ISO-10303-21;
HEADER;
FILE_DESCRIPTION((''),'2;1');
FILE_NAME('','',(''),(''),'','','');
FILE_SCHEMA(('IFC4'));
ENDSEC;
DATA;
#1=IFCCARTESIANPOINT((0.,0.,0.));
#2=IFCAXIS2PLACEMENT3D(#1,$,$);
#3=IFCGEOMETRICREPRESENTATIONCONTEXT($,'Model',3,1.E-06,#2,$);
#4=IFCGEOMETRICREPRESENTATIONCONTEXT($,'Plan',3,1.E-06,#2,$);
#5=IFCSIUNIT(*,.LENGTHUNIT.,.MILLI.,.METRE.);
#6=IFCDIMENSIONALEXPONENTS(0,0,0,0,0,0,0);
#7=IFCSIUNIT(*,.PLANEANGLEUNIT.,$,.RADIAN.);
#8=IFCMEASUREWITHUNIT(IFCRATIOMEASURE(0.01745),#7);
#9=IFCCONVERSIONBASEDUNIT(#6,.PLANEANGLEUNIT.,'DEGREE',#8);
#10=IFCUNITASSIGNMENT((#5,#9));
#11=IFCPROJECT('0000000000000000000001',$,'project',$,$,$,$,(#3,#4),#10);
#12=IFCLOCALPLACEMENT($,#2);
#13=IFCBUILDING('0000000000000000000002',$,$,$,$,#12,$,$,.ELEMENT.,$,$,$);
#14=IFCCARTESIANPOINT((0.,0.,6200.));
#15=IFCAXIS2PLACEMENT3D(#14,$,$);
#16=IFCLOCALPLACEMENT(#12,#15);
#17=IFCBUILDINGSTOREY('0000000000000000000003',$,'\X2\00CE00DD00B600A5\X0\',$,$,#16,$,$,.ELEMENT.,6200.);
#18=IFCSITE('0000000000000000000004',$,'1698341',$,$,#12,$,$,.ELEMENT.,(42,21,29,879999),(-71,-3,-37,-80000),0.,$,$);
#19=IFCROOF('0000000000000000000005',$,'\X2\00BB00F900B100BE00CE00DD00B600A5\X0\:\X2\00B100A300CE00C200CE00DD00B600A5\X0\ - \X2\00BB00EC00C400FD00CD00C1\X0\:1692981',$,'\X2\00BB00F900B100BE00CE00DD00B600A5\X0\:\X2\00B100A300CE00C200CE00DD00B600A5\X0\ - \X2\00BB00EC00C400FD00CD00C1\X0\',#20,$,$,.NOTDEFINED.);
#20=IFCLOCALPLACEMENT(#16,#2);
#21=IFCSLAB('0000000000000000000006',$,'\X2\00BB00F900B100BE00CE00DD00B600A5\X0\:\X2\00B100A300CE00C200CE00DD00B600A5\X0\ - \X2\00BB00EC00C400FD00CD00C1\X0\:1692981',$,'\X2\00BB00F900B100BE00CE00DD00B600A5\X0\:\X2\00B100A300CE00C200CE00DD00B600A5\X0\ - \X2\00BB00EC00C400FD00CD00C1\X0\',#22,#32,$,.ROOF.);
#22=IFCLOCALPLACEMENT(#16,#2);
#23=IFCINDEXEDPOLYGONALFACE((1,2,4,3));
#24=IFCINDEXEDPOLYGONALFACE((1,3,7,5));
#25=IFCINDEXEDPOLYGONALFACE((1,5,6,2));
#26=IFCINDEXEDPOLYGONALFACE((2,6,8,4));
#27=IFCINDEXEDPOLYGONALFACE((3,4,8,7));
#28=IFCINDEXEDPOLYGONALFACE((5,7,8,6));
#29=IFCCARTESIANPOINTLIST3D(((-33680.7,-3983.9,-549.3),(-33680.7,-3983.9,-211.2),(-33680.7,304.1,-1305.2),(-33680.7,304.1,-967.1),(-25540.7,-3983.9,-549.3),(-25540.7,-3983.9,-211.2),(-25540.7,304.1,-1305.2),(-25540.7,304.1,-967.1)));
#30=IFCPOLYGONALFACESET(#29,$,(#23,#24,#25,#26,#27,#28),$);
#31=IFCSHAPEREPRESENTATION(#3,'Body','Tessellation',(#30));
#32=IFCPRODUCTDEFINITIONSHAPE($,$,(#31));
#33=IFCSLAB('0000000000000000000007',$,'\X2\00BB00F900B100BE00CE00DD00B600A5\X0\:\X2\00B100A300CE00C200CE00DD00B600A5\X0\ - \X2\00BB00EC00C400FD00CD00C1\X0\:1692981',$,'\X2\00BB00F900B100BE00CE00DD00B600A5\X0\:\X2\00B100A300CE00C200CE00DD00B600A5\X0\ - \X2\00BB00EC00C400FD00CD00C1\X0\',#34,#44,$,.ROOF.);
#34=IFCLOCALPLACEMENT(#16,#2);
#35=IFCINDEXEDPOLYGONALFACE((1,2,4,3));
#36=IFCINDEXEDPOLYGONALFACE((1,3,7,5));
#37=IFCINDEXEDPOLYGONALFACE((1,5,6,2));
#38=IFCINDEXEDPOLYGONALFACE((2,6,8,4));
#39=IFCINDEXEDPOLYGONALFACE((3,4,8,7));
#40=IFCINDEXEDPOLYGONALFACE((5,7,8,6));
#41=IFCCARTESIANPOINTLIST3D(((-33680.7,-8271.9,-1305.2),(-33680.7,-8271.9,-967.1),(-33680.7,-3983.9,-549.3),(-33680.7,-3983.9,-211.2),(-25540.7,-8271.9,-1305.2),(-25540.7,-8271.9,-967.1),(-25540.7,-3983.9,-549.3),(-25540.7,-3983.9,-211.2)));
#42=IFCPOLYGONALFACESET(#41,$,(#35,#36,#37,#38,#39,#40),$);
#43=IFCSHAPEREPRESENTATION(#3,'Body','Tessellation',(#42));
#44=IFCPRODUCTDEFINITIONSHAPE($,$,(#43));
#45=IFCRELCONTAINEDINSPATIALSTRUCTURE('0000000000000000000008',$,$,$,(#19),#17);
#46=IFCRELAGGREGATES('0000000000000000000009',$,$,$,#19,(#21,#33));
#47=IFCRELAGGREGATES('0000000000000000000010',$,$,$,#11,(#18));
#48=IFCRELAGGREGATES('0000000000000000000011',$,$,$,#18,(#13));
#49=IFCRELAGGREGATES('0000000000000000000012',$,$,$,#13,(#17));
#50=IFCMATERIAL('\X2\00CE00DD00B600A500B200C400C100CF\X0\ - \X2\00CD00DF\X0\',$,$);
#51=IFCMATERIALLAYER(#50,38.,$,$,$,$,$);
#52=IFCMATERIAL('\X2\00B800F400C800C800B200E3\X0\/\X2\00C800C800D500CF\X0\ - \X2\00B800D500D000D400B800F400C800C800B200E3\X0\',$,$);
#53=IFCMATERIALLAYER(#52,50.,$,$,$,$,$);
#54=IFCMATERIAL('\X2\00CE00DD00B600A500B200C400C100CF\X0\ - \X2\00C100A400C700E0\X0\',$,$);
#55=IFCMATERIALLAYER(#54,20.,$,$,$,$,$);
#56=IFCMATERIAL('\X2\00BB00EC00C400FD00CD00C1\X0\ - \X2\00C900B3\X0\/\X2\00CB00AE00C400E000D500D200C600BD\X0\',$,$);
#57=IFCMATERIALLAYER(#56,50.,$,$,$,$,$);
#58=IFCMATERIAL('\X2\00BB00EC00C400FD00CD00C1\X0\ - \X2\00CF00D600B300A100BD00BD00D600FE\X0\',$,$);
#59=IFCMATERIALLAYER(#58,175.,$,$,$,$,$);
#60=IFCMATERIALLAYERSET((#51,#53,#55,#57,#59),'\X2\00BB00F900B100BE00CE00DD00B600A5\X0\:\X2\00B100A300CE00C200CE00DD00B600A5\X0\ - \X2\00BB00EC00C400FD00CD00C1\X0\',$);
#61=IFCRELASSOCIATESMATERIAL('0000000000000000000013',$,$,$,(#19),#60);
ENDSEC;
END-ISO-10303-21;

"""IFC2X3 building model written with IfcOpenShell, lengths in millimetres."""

from ifc_helpers import new_model, entity, si_unit, converted_unit, frame, frame_2d, origin, place, context, project, spatial, rectangle, extrude, material, layer, layer_set, layer_usage, element, aggregate, save


model = new_model("IFC2X3")

# Units and contexts
model_context = context("Model", 3, precision=1e-06, world=origin())
plan_context = context("Plan", 3, precision=1e-06, world=origin())
ifc_project = project(units=[si_unit("LENGTHUNIT", "METRE", prefix="MILLI"), converted_unit("PLANEANGLEUNIT", "DEGREE", entity("IfcRatioMeasure", 0.01745), si_unit("PLANEANGLEUNIT", "RADIAN"), dimensions=[0, 0, 0, 0, 0, 0, 0])], contexts=[model_context, plan_context])

# Site, building, storey
placement_1 = place(None, origin())
site = spatial("IfcSite", under=ifc_project, at=placement_1, Name="1698341", CompositionType="ELEMENT", RefLatitude=(42, 21, 29, 879999), RefLongitude=(-71, -3, -37, -80000), RefElevation=0.0)
building = spatial("IfcBuilding", under=site, at=placement_1, CompositionType="ELEMENT")
storey_placement = place(placement_1, frame((0.0, 0.0, 6200.0)))
storey = spatial("IfcBuildingStorey", under=building, at=storey_placement, Name="ÎÝ¶¥", CompositionType="ELEMENT", Elevation=6200.0)

# Roof, slabs
ifc_material_1 = material(Name="ÎÝ¶¥²ÄÁÏ - Íß")
ifc_layer_1 = layer(ifc_material_1, 38.0)
ifc_material_2 = material(Name="¸ôÈÈ²ã/ÈÈÕÏ - ¸ÕÐÔ¸ôÈÈ²ã")
ifc_layer_2 = layer(ifc_material_2, 50.0)
ifc_material_3 = material(Name="ÎÝ¶¥²ÄÁÏ - Á¤Çà")
ifc_layer_3 = layer(ifc_material_3, 20.0)
ifc_material_4 = material(Name="»ìÄýÍÁ - É³/Ë®ÄàÕÒÆ½")
ifc_layer_4 = layer(ifc_material_4, 50.0)
ifc_material_5 = material(Name="»ìÄýÍÁ - ÏÖ³¡½½Öþ")
ifc_layer_5 = layer(ifc_material_5, 175.0)
ifc_layer_set = layer_set([ifc_layer_1, ifc_layer_2, ifc_layer_3, ifc_layer_4, ifc_layer_5], Name="»ù±¾ÎÝ¶¥:±£ÎÂÎÝ¶¥ - »ìÄýÍÁ")
ifc_layer_usage = layer_usage(ifc_layer_set, "AXIS3", "NEGATIVE", 0.0)
roof_placement = place(storey_placement, origin())
roof = element("IfcRoof", 1, at=roof_placement, inside=storey, material=ifc_layer_usage, Name="»ù±¾ÎÝ¶¥:±£ÎÂÎÝ¶¥ - »ìÄýÍÁ:1692981", ObjectType="»ù±¾ÎÝ¶¥:±£ÎÂÎÝ¶¥ - »ìÄýÍÁ", ShapeType="NOTDEFINED")
placement_2 = place(roof_placement, frame((-33680.7, -8271.9, -1305.3)))
slab_1 = element("IfcSlab", 2, at=placement_2, Name="»ù±¾ÎÝ¶¥:±£ÎÂÎÝ¶¥ - »ìÄýÍÁ:1692981", ObjectType="»ù±¾ÎÝ¶¥:±£ÎÂÎÝ¶¥ - »ìÄýÍÁ", PredefinedType="ROOF", context=model_context, shape_type="SweptSolid", body=[
    extrude(rectangle(XDim=8140.0, YDim=4354.1, at=frame_2d((0.0, 0.0), x_axis=(-1.0, 0.0))), frame((4070.0, 6431.9, 378.0), z_axis=(0.0, 0.1736, 0.9848), x_axis=(1.0, 0.0, 0.0)), (0.0, -0.1736, 0.9848), 338.1),
])
slab_2 = element("IfcSlab", 3, at=placement_2, Name="»ù±¾ÎÝ¶¥:±£ÎÂÎÝ¶¥ - »ìÄýÍÁ:1692981", ObjectType="»ù±¾ÎÝ¶¥:±£ÎÂÎÝ¶¥ - »ìÄýÍÁ", PredefinedType="ROOF", context=model_context, shape_type="SweptSolid", body=[
    extrude(rectangle(XDim=8140.0, YDim=4354.1, at=frame_2d((0.0, 0.0), x_axis=(-1.0, 0.0))), frame((4070.0, 2144.0, 378.0), z_axis=(0.0, -0.1736, 0.9848), x_axis=(1.0, 0.0, 0.0)), (0.0, 0.1736, 0.9848), 338.1),
])
aggregate(roof, [slab_1, slab_2])

save(model, "model.ifc")
